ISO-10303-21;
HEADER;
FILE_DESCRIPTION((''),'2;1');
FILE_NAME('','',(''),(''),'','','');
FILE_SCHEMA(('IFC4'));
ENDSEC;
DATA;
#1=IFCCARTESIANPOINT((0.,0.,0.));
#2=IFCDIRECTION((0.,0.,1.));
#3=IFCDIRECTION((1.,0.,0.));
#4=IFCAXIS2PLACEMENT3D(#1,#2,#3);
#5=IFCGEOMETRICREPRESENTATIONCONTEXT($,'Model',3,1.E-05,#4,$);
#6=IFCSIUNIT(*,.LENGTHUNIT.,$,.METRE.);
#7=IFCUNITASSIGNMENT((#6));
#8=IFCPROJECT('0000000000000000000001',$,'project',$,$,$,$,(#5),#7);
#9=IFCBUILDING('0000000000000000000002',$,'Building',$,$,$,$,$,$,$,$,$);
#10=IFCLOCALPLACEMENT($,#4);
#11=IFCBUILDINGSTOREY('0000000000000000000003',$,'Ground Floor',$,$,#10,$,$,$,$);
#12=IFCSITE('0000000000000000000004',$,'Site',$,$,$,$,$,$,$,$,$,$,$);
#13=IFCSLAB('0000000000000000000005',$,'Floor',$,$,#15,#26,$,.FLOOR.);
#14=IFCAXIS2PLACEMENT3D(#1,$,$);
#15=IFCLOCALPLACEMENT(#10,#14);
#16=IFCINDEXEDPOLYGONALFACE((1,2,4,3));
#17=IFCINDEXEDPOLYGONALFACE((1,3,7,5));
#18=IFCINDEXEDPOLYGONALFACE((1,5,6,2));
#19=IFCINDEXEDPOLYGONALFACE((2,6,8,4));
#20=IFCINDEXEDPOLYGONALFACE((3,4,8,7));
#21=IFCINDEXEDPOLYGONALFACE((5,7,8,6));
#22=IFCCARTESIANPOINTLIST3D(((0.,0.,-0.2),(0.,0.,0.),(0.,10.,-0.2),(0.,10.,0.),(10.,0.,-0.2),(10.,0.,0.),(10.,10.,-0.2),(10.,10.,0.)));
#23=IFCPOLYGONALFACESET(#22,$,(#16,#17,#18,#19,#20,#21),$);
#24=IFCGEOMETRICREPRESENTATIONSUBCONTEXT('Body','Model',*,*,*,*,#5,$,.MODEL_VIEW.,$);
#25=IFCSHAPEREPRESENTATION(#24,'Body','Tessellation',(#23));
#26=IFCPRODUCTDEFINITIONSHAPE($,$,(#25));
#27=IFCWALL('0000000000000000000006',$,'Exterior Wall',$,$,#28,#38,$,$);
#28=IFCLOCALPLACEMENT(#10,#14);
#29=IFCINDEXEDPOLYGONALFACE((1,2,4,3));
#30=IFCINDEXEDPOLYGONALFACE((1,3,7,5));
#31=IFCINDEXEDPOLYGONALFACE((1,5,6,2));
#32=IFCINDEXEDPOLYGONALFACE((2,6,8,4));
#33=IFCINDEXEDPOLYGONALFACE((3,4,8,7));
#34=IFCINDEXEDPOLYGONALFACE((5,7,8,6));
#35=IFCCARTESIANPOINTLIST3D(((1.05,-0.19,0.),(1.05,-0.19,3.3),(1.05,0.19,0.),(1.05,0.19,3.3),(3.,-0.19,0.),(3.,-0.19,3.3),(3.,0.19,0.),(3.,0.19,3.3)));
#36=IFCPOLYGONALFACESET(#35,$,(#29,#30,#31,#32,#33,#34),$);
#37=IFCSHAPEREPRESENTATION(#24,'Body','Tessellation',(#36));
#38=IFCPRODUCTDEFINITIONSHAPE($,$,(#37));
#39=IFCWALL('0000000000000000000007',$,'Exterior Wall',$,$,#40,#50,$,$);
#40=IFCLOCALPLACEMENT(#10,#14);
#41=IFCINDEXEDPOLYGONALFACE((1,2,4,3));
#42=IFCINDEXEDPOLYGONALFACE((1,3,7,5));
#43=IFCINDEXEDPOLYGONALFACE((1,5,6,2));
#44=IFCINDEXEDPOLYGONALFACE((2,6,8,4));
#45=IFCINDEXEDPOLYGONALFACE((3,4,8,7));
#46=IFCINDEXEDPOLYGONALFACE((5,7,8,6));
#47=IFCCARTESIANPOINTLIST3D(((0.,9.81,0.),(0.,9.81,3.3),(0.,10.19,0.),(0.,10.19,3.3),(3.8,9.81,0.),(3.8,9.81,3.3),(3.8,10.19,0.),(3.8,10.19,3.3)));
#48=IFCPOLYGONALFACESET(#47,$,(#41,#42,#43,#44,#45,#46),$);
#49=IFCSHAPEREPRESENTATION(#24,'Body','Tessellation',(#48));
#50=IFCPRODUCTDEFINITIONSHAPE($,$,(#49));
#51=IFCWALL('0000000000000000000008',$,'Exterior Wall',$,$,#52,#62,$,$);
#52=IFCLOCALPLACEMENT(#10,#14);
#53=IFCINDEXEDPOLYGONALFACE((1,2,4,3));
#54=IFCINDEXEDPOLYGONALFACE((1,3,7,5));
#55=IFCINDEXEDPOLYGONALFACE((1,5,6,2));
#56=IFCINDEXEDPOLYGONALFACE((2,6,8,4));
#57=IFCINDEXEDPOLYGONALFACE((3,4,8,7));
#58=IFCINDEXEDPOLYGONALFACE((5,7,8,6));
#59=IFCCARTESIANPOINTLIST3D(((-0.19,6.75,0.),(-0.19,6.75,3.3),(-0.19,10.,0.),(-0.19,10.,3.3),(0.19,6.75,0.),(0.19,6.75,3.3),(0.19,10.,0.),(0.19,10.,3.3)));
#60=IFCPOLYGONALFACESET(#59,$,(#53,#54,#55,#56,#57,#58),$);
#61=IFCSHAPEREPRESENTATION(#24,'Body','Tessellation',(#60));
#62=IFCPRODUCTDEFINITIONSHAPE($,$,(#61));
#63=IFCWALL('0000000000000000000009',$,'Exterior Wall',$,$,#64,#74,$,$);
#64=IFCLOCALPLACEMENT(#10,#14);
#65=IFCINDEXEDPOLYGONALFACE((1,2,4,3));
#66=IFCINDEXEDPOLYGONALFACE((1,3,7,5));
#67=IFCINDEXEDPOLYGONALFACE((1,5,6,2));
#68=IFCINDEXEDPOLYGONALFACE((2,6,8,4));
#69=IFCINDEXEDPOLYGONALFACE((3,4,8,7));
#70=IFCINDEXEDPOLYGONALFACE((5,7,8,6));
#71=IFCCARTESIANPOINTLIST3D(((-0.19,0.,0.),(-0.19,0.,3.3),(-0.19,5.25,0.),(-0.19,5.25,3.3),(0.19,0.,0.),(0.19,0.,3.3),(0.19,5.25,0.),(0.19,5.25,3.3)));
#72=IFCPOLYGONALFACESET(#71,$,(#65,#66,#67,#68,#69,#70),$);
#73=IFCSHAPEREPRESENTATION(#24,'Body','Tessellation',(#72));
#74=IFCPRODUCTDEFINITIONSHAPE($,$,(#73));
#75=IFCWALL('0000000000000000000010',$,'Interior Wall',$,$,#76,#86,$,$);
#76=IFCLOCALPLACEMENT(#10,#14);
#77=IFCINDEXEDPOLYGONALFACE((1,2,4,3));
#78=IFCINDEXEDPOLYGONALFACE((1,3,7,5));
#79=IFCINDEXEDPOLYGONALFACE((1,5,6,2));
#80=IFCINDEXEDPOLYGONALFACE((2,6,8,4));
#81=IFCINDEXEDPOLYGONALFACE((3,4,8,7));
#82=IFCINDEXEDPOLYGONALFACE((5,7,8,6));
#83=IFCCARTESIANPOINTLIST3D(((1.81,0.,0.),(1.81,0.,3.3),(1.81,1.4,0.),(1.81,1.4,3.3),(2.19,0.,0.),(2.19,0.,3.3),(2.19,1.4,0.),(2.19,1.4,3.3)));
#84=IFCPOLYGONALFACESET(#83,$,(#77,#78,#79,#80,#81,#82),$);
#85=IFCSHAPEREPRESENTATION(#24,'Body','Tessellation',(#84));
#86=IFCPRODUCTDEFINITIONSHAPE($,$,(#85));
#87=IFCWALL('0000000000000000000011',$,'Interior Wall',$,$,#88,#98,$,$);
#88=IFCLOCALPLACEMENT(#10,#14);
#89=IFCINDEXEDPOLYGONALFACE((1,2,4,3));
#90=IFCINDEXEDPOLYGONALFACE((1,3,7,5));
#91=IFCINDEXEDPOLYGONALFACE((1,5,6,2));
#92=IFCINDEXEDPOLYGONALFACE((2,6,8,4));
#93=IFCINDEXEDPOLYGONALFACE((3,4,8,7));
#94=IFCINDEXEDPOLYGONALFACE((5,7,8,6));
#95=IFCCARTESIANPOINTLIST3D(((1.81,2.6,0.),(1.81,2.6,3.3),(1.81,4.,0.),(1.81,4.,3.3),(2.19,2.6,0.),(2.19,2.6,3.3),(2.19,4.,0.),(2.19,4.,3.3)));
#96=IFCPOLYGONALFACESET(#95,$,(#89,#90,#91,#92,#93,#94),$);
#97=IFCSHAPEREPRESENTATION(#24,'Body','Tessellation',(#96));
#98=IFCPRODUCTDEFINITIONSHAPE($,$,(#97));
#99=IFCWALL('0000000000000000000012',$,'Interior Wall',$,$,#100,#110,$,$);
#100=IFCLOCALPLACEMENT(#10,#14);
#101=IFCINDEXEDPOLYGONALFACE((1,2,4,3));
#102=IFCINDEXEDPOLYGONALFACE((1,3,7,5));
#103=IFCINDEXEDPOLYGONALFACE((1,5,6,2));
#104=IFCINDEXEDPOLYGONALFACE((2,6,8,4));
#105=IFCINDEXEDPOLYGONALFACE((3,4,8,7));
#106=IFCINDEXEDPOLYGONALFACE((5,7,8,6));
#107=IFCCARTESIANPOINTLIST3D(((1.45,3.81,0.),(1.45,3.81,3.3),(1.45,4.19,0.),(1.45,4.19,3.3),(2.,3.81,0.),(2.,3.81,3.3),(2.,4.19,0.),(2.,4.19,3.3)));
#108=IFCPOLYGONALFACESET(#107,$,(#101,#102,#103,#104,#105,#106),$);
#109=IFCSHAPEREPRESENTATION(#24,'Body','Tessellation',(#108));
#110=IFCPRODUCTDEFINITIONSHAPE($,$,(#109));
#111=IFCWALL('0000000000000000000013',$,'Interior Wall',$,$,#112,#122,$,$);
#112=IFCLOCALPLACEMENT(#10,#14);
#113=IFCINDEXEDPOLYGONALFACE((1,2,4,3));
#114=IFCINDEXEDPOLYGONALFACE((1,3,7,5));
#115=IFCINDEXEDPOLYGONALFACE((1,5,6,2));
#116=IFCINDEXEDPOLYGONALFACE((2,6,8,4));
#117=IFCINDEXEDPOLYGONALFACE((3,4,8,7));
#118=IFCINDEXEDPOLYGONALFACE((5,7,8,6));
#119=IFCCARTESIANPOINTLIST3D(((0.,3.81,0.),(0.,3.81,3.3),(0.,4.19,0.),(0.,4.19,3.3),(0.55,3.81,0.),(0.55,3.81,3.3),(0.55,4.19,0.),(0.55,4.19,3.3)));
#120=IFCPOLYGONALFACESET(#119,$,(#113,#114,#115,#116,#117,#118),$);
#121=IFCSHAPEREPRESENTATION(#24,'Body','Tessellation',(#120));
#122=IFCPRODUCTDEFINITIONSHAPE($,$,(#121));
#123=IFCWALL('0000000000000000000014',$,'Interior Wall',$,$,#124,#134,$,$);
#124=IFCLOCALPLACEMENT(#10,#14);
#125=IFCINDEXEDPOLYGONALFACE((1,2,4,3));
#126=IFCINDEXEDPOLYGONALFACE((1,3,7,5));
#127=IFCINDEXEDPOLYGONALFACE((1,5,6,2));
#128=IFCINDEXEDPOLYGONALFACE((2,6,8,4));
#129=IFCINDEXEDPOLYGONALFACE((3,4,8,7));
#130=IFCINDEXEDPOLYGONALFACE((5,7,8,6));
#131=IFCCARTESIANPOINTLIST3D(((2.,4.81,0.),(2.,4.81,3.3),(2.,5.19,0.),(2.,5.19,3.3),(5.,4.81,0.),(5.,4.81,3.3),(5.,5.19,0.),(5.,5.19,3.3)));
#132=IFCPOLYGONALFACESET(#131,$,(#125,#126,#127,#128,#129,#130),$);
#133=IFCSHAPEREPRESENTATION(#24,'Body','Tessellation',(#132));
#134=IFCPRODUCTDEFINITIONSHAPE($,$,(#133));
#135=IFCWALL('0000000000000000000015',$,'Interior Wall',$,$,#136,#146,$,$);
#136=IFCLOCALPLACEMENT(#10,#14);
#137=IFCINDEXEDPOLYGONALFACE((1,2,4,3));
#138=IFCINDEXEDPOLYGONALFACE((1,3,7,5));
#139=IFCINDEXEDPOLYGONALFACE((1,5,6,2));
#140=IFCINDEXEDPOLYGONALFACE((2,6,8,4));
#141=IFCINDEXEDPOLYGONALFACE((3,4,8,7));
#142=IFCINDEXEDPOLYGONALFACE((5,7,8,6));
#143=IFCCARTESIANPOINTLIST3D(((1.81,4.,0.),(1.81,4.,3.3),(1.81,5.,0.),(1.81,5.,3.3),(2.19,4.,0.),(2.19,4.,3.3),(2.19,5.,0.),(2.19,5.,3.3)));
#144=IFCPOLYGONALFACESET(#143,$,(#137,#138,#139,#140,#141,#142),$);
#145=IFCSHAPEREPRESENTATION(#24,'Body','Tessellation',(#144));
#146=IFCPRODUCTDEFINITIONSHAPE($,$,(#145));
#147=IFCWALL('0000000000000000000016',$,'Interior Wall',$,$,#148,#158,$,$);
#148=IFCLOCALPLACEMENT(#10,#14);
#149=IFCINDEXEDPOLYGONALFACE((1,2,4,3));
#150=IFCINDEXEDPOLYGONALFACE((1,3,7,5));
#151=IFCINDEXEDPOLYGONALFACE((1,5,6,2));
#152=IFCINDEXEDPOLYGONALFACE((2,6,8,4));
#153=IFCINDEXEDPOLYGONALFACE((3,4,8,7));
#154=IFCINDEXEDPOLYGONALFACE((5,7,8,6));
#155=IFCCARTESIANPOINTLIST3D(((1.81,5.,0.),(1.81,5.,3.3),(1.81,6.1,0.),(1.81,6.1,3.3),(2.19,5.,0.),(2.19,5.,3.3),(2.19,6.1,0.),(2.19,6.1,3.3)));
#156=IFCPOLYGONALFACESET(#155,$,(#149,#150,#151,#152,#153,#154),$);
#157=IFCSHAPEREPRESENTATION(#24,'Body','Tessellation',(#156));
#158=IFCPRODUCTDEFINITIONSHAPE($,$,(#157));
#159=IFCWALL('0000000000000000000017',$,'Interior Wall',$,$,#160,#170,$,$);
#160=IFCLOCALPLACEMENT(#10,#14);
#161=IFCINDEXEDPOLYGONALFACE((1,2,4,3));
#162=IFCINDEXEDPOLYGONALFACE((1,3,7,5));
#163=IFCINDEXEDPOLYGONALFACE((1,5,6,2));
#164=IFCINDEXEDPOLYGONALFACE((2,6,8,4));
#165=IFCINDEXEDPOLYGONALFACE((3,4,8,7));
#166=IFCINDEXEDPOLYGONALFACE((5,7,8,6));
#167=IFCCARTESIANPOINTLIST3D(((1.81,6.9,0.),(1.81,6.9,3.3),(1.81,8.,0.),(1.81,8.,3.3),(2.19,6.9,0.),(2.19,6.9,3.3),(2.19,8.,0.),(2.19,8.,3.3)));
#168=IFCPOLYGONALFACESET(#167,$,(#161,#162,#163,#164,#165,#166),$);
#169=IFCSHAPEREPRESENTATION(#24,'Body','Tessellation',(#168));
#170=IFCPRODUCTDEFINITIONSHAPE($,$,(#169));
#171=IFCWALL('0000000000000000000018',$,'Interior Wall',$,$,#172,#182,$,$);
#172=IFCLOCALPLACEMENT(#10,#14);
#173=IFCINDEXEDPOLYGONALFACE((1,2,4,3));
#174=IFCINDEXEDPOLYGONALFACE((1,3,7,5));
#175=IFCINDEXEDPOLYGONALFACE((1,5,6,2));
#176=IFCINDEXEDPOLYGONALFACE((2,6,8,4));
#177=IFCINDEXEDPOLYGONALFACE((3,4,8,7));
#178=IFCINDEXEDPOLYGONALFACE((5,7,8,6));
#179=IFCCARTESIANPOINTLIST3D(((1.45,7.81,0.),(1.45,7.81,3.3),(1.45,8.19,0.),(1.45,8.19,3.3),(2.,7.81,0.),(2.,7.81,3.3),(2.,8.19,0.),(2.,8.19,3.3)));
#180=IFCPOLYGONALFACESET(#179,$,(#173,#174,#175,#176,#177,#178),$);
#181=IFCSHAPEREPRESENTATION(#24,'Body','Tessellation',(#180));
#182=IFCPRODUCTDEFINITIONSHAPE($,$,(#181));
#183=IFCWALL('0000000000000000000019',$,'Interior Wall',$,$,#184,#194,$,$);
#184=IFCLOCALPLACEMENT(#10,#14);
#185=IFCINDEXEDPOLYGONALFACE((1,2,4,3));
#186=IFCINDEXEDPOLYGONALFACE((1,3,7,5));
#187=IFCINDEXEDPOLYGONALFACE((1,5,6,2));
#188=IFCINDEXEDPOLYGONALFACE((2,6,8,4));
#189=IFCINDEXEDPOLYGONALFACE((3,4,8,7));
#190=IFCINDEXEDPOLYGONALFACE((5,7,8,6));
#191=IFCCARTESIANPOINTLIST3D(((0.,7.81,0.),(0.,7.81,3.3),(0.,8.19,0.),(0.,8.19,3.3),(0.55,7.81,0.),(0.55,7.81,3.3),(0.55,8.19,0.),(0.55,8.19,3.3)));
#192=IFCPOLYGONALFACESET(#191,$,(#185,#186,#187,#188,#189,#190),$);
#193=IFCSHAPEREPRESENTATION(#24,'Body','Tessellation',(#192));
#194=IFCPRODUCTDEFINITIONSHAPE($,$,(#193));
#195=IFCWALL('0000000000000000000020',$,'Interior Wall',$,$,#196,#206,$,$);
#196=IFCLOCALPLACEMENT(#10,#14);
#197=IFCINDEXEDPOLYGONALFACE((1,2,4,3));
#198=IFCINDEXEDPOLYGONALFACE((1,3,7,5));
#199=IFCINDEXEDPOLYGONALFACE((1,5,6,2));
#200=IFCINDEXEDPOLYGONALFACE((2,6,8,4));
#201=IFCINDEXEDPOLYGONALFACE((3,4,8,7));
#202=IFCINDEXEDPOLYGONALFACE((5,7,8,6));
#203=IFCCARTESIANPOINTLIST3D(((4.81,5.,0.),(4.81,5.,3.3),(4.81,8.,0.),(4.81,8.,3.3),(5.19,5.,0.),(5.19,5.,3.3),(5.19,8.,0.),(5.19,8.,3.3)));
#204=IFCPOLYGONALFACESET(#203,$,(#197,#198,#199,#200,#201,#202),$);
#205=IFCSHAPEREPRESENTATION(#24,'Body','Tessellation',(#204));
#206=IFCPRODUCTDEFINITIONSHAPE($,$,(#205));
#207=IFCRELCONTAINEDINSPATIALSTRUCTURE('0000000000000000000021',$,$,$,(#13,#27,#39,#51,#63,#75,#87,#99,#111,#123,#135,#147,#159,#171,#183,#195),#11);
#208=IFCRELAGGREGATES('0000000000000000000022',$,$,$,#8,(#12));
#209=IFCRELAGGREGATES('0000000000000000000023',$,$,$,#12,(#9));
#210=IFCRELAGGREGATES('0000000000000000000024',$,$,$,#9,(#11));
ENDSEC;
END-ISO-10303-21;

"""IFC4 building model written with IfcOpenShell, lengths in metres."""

from ifc_helpers import new_model, si_unit, frame, origin_with_axes, place, context, subcontext, project, spatial, indexed_curve, outline, extrude, element, save


model = new_model("IFC4")

# Units and contexts
model_context = context("Model", 3, precision=1e-05, world=origin_with_axes())
body_context = subcontext(model_context, "Body", "Model", "MODEL_VIEW")
ifc_project = project(units=[si_unit("LENGTHUNIT", "METRE")], contexts=[model_context])

# Site, building, storey
site = spatial("IfcSite", under=ifc_project, Name="Site")
building = spatial("IfcBuilding", under=site, Name="Building")
storey_placement = place(None, origin_with_axes())
storey = spatial("IfcBuildingStorey", under=building, at=storey_placement, Name="Ground Floor")

# Slab
slab_placement = place(storey_placement, frame((0.0, 0.0, -0.2), z_axis=(0.0, 0.0, 1.0), x_axis=(1.0, 0.0, 0.0)))
element("IfcSlab", 1, at=slab_placement, inside=storey, Name="Floor", PredefinedType="FLOOR", context=body_context, shape_type="SweptSolid", body=[
    extrude(outline(indexed_curve([(0.0, 0.0), (10.0, 0.0), (10.0, 10.0), (0.0, 10.0)])), None, (0.0, 0.0, 1.0), 0.2),
])

# Walls
wall_1_placement = place(storey_placement, frame((1.05, 0.0, 0.0), z_axis=(0.0, 0.0, 1.0), x_axis=(1.0, 0.0, 0.0)))
element("IfcWall", 2, at=wall_1_placement, inside=storey, Name="Exterior Wall", context=body_context, shape_type="SweptSolid", body=[
    extrude(outline(indexed_curve([(0.0, 0.0), (0.0, 0.38), (1.95, 0.38), (1.95, 0.0), (0.0, 0.0)], self_intersect=False)), frame((0.0, -0.19, 0.0), z_axis=(0.0, 0.0, 1.0), x_axis=(1.0, 0.0, 0.0)), (0.0, 0.0, 1.0), 3.3),
])
wall_2_placement = place(storey_placement, frame((3.8, 10.0, 0.0), z_axis=(0.0, 0.0, 1.0), x_axis=(-1.0, 0.0, 0.0)))
element("IfcWall", 3, at=wall_2_placement, inside=storey, Name="Exterior Wall", context=body_context, shape_type="SweptSolid", body=[
    extrude(outline(indexed_curve([(0.0, 0.0), (0.0, 0.38), (3.8, 0.38), (3.8, 0.0), (0.0, 0.0)], self_intersect=False)), frame((0.0, -0.19, 0.0), z_axis=(0.0, 0.0, 1.0), x_axis=(1.0, 0.0, 0.0)), (0.0, 0.0, 1.0), 3.3),
])
wall_3_placement = place(storey_placement, frame((0.0, 10.0, 0.0), z_axis=(0.0, 0.0, 1.0), x_axis=(0.0, -1.0, 0.0)))
element("IfcWall", 4, at=wall_3_placement, inside=storey, Name="Exterior Wall", context=body_context, shape_type="SweptSolid", body=[
    extrude(outline(indexed_curve([(0.0, 0.0), (0.0, 0.38), (3.25, 0.38), (3.25, 0.0), (0.0, 0.0)], self_intersect=False)), frame((0.0, -0.19, 0.0), z_axis=(0.0, 0.0, 1.0), x_axis=(1.0, 0.0, 0.0)), (0.0, 0.0, 1.0), 3.3),
])
wall_4_placement = place(storey_placement, frame((0.0, 5.25, 0.0), z_axis=(0.0, 0.0, 1.0), x_axis=(0.0, -1.0, 0.0)))
element("IfcWall", 5, at=wall_4_placement, inside=storey, Name="Exterior Wall", context=body_context, shape_type="SweptSolid", body=[
    extrude(outline(indexed_curve([(0.0, 0.0), (0.0, 0.38), (5.25, 0.38), (5.25, 0.0), (0.0, 0.0)], self_intersect=False)), frame((0.0, -0.19, 0.0), z_axis=(0.0, 0.0, 1.0), x_axis=(1.0, 0.0, 0.0)), (0.0, 0.0, 1.0), 3.3),
])
for number, where, z_axis, x_axis, name in (
    (6, (2.0, 0.0, 0.0), (0.0, 0.0, 1.0), (0.0, 1.0, 0.0), "Interior Wall"),
    (7, (2.0, 2.6, 0.0), (0.0, 0.0, 1.0), (0.0, 1.0, 0.0), "Interior Wall"),
):
    element("IfcWall", number, at=place(storey_placement, frame(where, z_axis=z_axis, x_axis=x_axis)), inside=storey, Name=name, context=body_context, shape_type="SweptSolid", body=[
        extrude(outline(indexed_curve([(0.0, 0.0), (0.0, 0.38), (1.4, 0.38), (1.4, 0.0), (0.0, 0.0)], self_intersect=False)), frame((0.0, -0.19, 0.0), z_axis=(0.0, 0.0, 1.0), x_axis=(1.0, 0.0, 0.0)), (0.0, 0.0, 1.0), 3.3),
    ])
for number, where, z_axis, x_axis, name in (
    (8, (2.0, 4.0, 0.0), (0.0, 0.0, 1.0), (-1.0, 0.0, 0.0), "Interior Wall"),
    (9, (0.55, 4.0, 0.0), (0.0, 0.0, 1.0), (-1.0, 0.0, 0.0), "Interior Wall"),
):
    element("IfcWall", number, at=place(storey_placement, frame(where, z_axis=z_axis, x_axis=x_axis)), inside=storey, Name=name, context=body_context, shape_type="SweptSolid", body=[
        extrude(outline(indexed_curve([(0.0, 0.0), (0.0, 0.38), (0.55, 0.38), (0.55, 0.0), (0.0, 0.0)], self_intersect=False)), frame((0.0, -0.19, 0.0), z_axis=(0.0, 0.0, 1.0), x_axis=(1.0, 0.0, 0.0)), (0.0, 0.0, 1.0), 3.3),
    ])
wall_5_placement = place(storey_placement, frame((5.0, 5.0, 0.0), z_axis=(0.0, 0.0, 1.0), x_axis=(-1.0, 0.0, 0.0)))
element("IfcWall", 10, at=wall_5_placement, inside=storey, Name="Interior Wall", context=body_context, shape_type="SweptSolid", body=[
    extrude(outline(indexed_curve([(0.0, 0.0), (0.0, 0.38), (3.0, 0.38), (3.0, 0.0), (0.0, 0.0)], self_intersect=False)), frame((0.0, -0.19, 0.0), z_axis=(0.0, 0.0, 1.0), x_axis=(1.0, 0.0, 0.0)), (0.0, 0.0, 1.0), 3.3),
])
wall_6_placement = place(storey_placement, frame((2.0, 5.0, 0.0), z_axis=(0.0, 0.0, 1.0), x_axis=(0.0, -1.0, 0.0)))
element("IfcWall", 11, at=wall_6_placement, inside=storey, Name="Interior Wall", context=body_context, shape_type="SweptSolid", body=[
    extrude(outline(indexed_curve([(0.0, 0.0), (0.0, 0.38), (1.0, 0.38), (1.0, 0.0), (0.0, 0.0)], self_intersect=False)), frame((0.0, -0.19, 0.0), z_axis=(0.0, 0.0, 1.0), x_axis=(1.0, 0.0, 0.0)), (0.0, 0.0, 1.0), 3.3),
])
for number, where, z_axis, x_axis, name in (
    (12, (2.0, 5.0, 0.0), (0.0, 0.0, 1.0), (0.0, 1.0, 0.0), "Interior Wall"),
    (13, (2.0, 6.9, 0.0), (0.0, 0.0, 1.0), (0.0, 1.0, 0.0), "Interior Wall"),
):
    element("IfcWall", number, at=place(storey_placement, frame(where, z_axis=z_axis, x_axis=x_axis)), inside=storey, Name=name, context=body_context, shape_type="SweptSolid", body=[
        extrude(outline(indexed_curve([(0.0, 0.0), (0.0, 0.38), (1.1, 0.38), (1.1, 0.0), (0.0, 0.0)], self_intersect=False)), frame((0.0, -0.19, 0.0), z_axis=(0.0, 0.0, 1.0), x_axis=(1.0, 0.0, 0.0)), (0.0, 0.0, 1.0), 3.3),
    ])
for number, where, z_axis, x_axis, name in (
    (14, (2.0, 8.0, 0.0), (0.0, 0.0, 1.0), (-1.0, 0.0, 0.0), "Interior Wall"),
    (15, (0.55, 8.0, 0.0), (0.0, 0.0, 1.0), (-1.0, 0.0, 0.0), "Interior Wall"),
):
    element("IfcWall", number, at=place(storey_placement, frame(where, z_axis=z_axis, x_axis=x_axis)), inside=storey, Name=name, context=body_context, shape_type="SweptSolid", body=[
        extrude(outline(indexed_curve([(0.0, 0.0), (0.0, 0.38), (0.55, 0.38), (0.55, 0.0), (0.0, 0.0)], self_intersect=False)), frame((0.0, -0.19, 0.0), z_axis=(0.0, 0.0, 1.0), x_axis=(1.0, 0.0, 0.0)), (0.0, 0.0, 1.0), 3.3),
    ])
wall_7_placement = place(storey_placement, frame((5.0, 5.0, 0.0), z_axis=(0.0, 0.0, 1.0), x_axis=(0.0, 1.0, 0.0)))
element("IfcWall", 16, at=wall_7_placement, inside=storey, Name="Interior Wall", context=body_context, shape_type="SweptSolid", body=[
    extrude(outline(indexed_curve([(0.0, 0.0), (0.0, 0.38), (3.0, 0.38), (3.0, 0.0), (0.0, 0.0)], self_intersect=False)), frame((0.0, -0.19, 0.0), z_axis=(0.0, 0.0, 1.0), x_axis=(1.0, 0.0, 0.0)), (0.0, 0.0, 1.0), 3.3),
])

save(model, "model.ifc")
